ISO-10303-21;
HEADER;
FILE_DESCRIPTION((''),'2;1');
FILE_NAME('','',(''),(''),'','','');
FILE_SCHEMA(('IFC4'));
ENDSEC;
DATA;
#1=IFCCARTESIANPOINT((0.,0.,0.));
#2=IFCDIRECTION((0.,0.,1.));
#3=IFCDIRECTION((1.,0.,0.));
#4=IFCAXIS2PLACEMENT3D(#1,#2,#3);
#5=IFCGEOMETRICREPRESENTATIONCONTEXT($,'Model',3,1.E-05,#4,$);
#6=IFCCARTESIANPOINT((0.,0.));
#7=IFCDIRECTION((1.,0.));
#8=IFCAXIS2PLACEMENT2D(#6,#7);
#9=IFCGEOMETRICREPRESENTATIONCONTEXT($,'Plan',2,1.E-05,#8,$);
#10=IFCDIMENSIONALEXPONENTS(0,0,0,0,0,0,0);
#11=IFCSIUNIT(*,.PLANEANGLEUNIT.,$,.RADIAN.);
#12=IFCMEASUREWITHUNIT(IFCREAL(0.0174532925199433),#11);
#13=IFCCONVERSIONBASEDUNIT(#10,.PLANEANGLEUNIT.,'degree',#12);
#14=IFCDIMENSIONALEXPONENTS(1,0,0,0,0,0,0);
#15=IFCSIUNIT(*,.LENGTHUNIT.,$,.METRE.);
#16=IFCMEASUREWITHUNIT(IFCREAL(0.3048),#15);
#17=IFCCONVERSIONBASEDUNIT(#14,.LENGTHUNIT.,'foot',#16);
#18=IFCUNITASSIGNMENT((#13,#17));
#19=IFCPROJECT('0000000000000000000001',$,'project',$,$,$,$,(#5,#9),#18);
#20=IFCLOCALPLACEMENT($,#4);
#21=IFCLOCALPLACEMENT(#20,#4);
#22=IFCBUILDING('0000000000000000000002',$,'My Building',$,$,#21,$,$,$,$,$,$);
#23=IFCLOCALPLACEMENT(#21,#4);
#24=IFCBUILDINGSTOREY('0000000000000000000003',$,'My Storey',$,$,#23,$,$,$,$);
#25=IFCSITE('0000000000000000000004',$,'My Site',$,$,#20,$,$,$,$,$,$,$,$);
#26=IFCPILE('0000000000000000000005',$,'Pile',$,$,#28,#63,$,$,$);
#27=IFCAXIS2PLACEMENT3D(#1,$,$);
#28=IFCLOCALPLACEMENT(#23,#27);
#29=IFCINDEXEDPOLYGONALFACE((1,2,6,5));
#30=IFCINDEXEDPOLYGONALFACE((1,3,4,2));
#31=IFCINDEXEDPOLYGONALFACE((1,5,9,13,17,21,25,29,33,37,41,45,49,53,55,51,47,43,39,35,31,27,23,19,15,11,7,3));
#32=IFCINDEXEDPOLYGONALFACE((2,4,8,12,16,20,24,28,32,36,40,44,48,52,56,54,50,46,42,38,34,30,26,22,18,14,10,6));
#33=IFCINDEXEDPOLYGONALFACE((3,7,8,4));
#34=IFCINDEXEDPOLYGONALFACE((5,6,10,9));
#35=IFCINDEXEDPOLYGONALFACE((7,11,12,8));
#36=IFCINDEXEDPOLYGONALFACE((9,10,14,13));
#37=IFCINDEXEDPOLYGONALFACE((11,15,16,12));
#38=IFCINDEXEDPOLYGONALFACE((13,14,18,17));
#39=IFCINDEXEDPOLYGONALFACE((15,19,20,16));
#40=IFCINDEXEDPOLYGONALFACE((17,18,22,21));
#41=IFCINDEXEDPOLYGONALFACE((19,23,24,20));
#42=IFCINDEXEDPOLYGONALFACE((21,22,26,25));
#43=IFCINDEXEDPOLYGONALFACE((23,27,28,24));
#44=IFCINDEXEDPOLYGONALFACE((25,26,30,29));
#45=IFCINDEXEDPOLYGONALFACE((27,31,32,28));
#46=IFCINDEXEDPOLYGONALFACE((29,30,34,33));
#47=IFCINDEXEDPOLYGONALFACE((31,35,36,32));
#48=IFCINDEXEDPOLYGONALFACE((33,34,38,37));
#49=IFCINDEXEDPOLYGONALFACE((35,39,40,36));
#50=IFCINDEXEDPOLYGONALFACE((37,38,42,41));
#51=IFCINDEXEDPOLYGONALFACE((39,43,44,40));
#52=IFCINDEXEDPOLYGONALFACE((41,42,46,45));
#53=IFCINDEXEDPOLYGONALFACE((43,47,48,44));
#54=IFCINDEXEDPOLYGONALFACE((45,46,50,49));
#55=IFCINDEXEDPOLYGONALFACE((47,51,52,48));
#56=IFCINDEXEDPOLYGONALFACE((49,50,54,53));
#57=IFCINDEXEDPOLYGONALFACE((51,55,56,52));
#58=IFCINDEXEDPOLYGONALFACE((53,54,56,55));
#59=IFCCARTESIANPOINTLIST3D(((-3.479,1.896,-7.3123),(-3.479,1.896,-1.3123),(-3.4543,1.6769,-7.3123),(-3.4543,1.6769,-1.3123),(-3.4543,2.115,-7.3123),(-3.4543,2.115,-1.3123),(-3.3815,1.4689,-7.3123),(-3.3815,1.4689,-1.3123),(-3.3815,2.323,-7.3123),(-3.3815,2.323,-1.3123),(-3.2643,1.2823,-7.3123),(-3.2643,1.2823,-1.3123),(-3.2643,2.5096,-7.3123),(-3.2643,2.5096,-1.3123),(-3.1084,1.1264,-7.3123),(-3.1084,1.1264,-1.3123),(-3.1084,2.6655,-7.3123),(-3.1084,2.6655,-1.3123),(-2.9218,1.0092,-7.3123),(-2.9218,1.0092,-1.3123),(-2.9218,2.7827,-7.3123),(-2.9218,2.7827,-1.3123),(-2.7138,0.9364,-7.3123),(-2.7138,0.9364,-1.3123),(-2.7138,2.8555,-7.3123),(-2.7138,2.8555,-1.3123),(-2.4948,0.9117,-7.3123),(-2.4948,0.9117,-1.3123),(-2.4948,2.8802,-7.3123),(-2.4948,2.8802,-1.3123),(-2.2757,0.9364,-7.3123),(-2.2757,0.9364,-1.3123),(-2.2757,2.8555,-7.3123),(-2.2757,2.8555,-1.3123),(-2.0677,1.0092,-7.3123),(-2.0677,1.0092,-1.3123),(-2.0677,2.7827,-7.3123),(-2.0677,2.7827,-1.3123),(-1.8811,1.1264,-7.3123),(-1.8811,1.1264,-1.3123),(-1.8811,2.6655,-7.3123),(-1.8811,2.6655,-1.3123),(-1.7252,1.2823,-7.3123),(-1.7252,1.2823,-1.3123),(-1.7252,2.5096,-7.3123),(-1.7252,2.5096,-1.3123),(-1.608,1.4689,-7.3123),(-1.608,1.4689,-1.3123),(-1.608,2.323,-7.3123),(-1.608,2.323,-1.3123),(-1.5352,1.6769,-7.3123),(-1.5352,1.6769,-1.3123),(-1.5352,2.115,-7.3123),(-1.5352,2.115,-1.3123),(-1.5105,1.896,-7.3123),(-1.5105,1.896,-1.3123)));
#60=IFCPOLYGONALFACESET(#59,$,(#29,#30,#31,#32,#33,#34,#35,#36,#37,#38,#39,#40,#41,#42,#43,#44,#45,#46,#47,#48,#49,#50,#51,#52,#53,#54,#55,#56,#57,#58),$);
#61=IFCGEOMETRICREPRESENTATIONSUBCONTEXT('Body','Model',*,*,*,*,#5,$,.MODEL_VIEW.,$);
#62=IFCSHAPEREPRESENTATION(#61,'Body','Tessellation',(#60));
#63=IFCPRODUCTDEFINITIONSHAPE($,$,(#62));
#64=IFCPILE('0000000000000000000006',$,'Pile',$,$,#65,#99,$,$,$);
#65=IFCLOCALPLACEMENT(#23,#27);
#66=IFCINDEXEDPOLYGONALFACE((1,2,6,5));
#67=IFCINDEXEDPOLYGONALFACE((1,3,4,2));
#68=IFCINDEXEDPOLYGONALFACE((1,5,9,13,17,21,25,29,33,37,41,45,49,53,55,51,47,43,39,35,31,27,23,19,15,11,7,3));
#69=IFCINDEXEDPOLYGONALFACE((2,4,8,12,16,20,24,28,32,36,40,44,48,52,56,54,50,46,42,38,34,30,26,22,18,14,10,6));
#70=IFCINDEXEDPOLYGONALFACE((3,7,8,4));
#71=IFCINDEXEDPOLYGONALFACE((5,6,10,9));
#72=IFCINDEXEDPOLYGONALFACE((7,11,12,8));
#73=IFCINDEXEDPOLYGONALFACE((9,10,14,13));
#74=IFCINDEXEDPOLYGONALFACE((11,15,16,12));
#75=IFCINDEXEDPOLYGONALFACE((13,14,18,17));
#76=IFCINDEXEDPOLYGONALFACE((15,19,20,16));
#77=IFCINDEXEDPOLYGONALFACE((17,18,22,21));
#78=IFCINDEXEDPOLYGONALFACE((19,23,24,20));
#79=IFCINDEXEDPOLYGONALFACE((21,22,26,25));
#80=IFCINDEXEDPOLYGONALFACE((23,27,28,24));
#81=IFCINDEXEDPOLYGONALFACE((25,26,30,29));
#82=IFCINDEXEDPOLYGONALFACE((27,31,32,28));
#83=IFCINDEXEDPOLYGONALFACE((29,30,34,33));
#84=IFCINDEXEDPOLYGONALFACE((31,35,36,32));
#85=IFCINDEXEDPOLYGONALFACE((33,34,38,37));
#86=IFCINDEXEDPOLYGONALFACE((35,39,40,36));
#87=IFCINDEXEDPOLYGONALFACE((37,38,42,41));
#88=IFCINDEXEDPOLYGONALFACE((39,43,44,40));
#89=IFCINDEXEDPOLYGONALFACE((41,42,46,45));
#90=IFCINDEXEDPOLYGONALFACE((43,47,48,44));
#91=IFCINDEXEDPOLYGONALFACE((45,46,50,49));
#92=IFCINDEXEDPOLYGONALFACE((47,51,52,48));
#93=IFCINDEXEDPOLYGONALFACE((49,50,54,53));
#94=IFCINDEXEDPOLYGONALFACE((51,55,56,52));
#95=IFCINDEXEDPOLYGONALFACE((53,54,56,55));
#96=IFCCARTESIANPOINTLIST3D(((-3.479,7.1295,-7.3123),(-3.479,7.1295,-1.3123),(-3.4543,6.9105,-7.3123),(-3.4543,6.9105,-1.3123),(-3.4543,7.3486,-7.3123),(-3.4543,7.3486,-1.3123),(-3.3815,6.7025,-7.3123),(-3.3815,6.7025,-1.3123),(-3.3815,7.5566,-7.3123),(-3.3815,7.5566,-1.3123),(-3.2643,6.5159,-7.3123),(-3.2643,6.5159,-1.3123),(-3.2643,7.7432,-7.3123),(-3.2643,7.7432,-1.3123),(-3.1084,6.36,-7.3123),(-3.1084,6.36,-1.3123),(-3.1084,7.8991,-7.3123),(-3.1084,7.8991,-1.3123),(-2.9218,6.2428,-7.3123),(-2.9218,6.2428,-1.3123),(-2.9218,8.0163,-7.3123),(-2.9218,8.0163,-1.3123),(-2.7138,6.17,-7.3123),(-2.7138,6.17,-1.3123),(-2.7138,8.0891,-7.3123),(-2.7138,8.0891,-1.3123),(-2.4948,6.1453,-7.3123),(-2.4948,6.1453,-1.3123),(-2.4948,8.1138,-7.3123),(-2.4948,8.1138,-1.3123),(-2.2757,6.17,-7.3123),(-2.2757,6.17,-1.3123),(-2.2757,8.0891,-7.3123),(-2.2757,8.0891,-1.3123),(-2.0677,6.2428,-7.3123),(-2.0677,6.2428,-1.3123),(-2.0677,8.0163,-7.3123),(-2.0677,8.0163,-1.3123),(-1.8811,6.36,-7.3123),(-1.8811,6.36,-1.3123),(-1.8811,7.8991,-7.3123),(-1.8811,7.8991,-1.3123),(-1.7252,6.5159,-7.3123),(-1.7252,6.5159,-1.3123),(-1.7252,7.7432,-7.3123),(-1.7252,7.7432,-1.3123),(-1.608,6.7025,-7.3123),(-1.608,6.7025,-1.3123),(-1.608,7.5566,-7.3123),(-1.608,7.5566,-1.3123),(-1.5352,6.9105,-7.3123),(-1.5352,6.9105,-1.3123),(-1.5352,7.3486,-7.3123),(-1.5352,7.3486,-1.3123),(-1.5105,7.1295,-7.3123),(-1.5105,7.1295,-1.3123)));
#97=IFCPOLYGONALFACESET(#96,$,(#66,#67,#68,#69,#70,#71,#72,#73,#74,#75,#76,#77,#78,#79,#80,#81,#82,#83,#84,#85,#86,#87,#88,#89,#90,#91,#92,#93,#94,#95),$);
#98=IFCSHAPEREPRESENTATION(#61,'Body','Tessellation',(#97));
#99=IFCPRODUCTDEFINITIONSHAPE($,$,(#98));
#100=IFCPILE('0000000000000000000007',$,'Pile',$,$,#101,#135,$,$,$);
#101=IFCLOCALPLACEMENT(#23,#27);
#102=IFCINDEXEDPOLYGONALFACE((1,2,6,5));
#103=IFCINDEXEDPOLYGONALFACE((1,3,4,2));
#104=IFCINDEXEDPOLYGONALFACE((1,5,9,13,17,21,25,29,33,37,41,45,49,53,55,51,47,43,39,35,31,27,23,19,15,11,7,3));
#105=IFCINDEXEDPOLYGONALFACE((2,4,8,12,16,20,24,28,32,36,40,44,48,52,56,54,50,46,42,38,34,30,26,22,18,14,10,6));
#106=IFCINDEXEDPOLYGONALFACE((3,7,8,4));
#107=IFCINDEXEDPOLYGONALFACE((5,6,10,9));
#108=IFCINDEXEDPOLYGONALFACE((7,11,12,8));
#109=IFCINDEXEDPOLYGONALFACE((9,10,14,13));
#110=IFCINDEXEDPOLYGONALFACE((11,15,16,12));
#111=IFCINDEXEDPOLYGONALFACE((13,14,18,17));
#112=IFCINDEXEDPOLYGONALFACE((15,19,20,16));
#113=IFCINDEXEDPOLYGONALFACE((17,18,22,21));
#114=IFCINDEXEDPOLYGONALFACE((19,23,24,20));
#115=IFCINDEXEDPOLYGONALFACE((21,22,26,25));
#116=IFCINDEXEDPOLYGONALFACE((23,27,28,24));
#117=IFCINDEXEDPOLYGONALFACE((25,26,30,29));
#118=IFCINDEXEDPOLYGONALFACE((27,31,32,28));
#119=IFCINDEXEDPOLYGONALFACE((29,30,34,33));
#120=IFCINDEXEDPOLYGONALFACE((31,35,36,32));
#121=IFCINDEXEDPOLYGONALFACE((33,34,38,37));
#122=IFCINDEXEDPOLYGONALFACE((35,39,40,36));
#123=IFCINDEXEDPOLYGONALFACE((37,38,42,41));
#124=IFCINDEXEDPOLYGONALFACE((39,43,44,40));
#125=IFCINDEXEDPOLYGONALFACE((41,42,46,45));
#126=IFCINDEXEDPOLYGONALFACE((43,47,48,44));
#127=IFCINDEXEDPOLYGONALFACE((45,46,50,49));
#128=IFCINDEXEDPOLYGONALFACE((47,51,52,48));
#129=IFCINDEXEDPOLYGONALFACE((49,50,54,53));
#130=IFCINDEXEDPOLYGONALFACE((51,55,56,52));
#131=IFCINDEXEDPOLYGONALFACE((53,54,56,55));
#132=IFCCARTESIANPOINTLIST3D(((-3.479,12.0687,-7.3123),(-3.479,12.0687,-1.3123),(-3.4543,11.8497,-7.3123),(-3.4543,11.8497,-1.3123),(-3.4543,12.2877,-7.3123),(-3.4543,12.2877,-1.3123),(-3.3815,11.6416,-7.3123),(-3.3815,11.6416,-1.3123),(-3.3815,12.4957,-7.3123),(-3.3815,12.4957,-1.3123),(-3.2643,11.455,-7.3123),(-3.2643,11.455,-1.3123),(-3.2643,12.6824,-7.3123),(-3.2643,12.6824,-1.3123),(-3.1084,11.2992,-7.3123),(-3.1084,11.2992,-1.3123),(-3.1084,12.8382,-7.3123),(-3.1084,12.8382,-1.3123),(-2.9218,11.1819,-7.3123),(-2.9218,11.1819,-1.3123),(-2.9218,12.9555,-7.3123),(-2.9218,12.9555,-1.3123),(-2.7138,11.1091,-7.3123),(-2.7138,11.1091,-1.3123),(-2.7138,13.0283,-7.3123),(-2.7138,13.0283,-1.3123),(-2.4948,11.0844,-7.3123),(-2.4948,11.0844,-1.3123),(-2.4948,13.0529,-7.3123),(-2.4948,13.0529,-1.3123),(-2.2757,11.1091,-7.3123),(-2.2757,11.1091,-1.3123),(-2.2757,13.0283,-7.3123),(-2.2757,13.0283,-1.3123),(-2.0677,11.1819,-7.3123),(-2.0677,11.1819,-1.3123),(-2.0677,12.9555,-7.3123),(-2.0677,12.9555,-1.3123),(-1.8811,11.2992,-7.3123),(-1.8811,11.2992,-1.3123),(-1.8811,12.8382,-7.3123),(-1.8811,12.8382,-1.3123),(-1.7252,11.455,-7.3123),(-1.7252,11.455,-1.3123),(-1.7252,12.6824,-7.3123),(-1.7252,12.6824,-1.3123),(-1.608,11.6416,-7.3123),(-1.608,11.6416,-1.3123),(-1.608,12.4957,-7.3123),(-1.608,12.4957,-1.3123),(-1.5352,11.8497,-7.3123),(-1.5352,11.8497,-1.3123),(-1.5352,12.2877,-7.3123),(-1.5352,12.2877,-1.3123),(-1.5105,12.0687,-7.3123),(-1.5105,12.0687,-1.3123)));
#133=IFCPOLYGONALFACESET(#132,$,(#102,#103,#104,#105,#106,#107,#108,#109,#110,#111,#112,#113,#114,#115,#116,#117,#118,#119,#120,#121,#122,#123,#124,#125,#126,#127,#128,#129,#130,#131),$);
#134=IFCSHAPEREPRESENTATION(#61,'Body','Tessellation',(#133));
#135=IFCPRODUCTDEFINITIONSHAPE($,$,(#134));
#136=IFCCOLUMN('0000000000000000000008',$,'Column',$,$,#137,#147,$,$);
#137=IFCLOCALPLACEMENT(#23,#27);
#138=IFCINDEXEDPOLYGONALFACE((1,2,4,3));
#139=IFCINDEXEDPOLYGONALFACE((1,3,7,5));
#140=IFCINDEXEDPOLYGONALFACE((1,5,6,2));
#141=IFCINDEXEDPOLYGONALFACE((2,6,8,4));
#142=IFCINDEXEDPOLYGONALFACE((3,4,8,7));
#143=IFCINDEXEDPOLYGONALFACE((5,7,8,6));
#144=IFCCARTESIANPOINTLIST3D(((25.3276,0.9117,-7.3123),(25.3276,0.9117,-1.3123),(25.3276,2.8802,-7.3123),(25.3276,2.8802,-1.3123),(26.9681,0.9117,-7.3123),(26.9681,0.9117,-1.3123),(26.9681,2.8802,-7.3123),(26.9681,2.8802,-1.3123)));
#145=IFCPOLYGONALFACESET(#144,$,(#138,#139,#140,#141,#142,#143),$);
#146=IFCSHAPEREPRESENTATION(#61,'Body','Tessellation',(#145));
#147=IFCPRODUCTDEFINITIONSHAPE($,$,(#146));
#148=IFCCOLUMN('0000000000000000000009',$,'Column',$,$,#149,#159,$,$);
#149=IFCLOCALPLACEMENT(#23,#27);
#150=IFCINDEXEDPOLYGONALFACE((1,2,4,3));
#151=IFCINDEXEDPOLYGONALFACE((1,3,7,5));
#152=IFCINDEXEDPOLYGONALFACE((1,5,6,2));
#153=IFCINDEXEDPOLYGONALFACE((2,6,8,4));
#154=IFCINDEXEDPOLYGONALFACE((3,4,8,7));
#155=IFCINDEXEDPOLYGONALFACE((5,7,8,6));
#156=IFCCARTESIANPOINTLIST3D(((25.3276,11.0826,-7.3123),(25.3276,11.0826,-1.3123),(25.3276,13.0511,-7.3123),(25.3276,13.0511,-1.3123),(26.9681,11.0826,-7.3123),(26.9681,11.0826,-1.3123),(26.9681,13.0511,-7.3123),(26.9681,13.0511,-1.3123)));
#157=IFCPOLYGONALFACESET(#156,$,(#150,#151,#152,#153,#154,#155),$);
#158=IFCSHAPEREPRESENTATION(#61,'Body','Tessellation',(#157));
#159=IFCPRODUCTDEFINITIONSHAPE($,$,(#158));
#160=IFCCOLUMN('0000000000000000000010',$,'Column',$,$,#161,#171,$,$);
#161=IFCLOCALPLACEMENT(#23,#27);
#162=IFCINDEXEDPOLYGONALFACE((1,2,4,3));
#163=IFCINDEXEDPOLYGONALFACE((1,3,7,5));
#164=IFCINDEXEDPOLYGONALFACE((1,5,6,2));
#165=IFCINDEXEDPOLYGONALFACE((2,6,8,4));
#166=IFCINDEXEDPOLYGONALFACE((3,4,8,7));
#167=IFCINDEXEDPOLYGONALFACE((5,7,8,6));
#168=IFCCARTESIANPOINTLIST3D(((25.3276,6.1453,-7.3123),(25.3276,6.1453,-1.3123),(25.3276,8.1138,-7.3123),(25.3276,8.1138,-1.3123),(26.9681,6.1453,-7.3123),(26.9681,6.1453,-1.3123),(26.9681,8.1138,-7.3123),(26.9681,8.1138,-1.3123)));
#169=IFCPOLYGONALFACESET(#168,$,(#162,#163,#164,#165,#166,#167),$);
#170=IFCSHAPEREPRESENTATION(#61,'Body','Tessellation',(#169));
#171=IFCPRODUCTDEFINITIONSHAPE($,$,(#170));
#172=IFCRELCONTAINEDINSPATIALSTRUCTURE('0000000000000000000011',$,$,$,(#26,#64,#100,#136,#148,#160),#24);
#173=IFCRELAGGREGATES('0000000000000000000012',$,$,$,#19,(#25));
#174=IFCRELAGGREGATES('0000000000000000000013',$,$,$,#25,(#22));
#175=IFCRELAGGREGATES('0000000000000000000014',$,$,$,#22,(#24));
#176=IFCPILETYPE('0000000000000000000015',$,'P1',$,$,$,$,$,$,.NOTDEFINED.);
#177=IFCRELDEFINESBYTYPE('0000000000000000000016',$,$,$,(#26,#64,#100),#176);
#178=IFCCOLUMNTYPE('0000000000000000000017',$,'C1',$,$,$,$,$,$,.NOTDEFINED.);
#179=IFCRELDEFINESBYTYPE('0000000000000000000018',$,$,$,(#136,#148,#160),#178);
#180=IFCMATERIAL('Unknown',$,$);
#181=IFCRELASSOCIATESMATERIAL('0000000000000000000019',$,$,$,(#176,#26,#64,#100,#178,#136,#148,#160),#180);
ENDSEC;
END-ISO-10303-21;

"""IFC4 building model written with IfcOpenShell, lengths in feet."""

from ifc_helpers import new_model, entity, si_unit, converted_unit, frame, origin_with_axes, origin_2d_with_axis, place, context, subcontext, project, spatial, rectangle, circle, extrude, material, material_profile, profile_set, profile_usage, type_object, element, save


model = new_model("IFC4")

# Units and contexts
model_context = context("Model", 3, precision=1e-05, world=origin_with_axes())
plan_context = context("Plan", 2, precision=1e-05, world=origin_2d_with_axis())
body_context_1 = subcontext(model_context, "Body", "Model", "MODEL_VIEW")
ifc_project = project(units=[converted_unit("PLANEANGLEUNIT", "degree", entity("IfcReal", 0.0174532925199433), si_unit("PLANEANGLEUNIT", "RADIAN"), dimensions=[0, 0, 0, 0, 0, 0, 0]), converted_unit("LENGTHUNIT", "foot", entity("IfcReal", 0.3048), si_unit("LENGTHUNIT", "METRE"), dimensions=[1, 0, 0, 0, 0, 0, 0])], contexts=[model_context, plan_context])

# Site, building, storey
site_placement = place(None, origin_with_axes())
site = spatial("IfcSite", under=ifc_project, at=site_placement, Name="My Site")
building_placement = place(site_placement, origin_with_axes())
building = spatial("IfcBuilding", under=site, at=building_placement, Name="My Building")
storey_placement = place(building_placement, origin_with_axes())
storey = spatial("IfcBuildingStorey", under=building, at=storey_placement, Name="My Storey")

# Piles
ifc_material = material(Name="Unknown")
ifc_material_profile_1 = material_profile(ifc_material, circle(Radius=0.9843))
ifc_profile_set_1 = profile_set([ifc_material_profile_1])
ifc_profile_usage_1 = profile_usage(ifc_profile_set_1, cardinal=5)
pile_type = type_object("IfcPileType", Name="P1", PredefinedType="NOTDEFINED", material=ifc_profile_set_1)
pile_1_placement = place(storey_placement, frame((-2.4948, 1.896, -7.3123), z_axis=(0.0, 0.0, 1.0), x_axis=(1.0, 0.0, 0.0)))
element("IfcPile", 1, at=pile_1_placement, inside=storey, type_object=pile_type, material=ifc_profile_usage_1, Name="Pile", context=body_context_1, shape_type="SweptSolid", body=[
    extrude(circle(Radius=0.9843), origin_with_axes(), (0.0, 0.0, 1.0), 6.0),
])
ifc_profile_usage_2 = profile_usage(ifc_profile_set_1, cardinal=5)
pile_2_placement = place(storey_placement, frame((-2.4948, 7.1295, -7.3123), z_axis=(0.0, 0.0, 1.0), x_axis=(1.0, 0.0, 0.0)))
element("IfcPile", 2, at=pile_2_placement, inside=storey, type_object=pile_type, material=ifc_profile_usage_2, Name="Pile", context=body_context_1, shape_type="SweptSolid", body=[
    extrude(circle(Radius=0.9843), origin_with_axes(), (0.0, 0.0, 1.0), 6.0),
])
ifc_profile_usage_3 = profile_usage(ifc_profile_set_1, cardinal=5)
pile_3_placement = place(storey_placement, frame((-2.4948, 12.0687, -7.3123), z_axis=(0.0, 0.0, 1.0), x_axis=(1.0, 0.0, 0.0)))
element("IfcPile", 3, at=pile_3_placement, inside=storey, type_object=pile_type, material=ifc_profile_usage_3, Name="Pile", context=body_context_1, shape_type="SweptSolid", body=[
    extrude(circle(Radius=0.9843), origin_with_axes(), (0.0, 0.0, 1.0), 6.0),
])

# Columns
ifc_material_profile_2 = material_profile(ifc_material, rectangle(XDim=1.6404, YDim=1.9685))
ifc_profile_set_2 = profile_set([ifc_material_profile_2])
ifc_profile_usage_4 = profile_usage(ifc_profile_set_2, cardinal=5)
column_type = type_object("IfcColumnType", Name="C1", PredefinedType="NOTDEFINED", material=ifc_profile_set_2)
column_1_placement = place(storey_placement, frame((26.1478, 1.896, -7.3123), z_axis=(0.0, 0.0, 1.0), x_axis=(1.0, 0.0, 0.0)))
element("IfcColumn", 4, at=column_1_placement, inside=storey, type_object=column_type, material=ifc_profile_usage_4, Name="Column", context=body_context_1, shape_type="SweptSolid", body=[
    extrude(rectangle(XDim=1.6404, YDim=1.9685), origin_with_axes(), (0.0, 0.0, 1.0), 6.0),
])
ifc_profile_usage_5 = profile_usage(ifc_profile_set_2, cardinal=5)
column_2_placement = place(storey_placement, frame((26.1478, 12.0669, -7.3123), z_axis=(0.0, 0.0, 1.0), x_axis=(1.0, 0.0, 0.0)))
element("IfcColumn", 5, at=column_2_placement, inside=storey, type_object=column_type, material=ifc_profile_usage_5, Name="Column", context=body_context_1, shape_type="SweptSolid", body=[
    extrude(rectangle(XDim=1.6404, YDim=1.9685), origin_with_axes(), (0.0, 0.0, 1.0), 6.0),
])
ifc_profile_usage_6 = profile_usage(ifc_profile_set_2, cardinal=5)
column_3_placement = place(storey_placement, frame((26.1478, 7.1295, -7.3123), z_axis=(0.0, 0.0, 1.0), x_axis=(1.0, 0.0, 0.0)))
element("IfcColumn", 6, at=column_3_placement, inside=storey, type_object=column_type, material=ifc_profile_usage_6, Name="Column", context=body_context_1, shape_type="SweptSolid", body=[
    extrude(rectangle(XDim=1.6404, YDim=1.9685), origin_with_axes(), (0.0, 0.0, 1.0), 6.0),
])

save(model, "model.ifc")
